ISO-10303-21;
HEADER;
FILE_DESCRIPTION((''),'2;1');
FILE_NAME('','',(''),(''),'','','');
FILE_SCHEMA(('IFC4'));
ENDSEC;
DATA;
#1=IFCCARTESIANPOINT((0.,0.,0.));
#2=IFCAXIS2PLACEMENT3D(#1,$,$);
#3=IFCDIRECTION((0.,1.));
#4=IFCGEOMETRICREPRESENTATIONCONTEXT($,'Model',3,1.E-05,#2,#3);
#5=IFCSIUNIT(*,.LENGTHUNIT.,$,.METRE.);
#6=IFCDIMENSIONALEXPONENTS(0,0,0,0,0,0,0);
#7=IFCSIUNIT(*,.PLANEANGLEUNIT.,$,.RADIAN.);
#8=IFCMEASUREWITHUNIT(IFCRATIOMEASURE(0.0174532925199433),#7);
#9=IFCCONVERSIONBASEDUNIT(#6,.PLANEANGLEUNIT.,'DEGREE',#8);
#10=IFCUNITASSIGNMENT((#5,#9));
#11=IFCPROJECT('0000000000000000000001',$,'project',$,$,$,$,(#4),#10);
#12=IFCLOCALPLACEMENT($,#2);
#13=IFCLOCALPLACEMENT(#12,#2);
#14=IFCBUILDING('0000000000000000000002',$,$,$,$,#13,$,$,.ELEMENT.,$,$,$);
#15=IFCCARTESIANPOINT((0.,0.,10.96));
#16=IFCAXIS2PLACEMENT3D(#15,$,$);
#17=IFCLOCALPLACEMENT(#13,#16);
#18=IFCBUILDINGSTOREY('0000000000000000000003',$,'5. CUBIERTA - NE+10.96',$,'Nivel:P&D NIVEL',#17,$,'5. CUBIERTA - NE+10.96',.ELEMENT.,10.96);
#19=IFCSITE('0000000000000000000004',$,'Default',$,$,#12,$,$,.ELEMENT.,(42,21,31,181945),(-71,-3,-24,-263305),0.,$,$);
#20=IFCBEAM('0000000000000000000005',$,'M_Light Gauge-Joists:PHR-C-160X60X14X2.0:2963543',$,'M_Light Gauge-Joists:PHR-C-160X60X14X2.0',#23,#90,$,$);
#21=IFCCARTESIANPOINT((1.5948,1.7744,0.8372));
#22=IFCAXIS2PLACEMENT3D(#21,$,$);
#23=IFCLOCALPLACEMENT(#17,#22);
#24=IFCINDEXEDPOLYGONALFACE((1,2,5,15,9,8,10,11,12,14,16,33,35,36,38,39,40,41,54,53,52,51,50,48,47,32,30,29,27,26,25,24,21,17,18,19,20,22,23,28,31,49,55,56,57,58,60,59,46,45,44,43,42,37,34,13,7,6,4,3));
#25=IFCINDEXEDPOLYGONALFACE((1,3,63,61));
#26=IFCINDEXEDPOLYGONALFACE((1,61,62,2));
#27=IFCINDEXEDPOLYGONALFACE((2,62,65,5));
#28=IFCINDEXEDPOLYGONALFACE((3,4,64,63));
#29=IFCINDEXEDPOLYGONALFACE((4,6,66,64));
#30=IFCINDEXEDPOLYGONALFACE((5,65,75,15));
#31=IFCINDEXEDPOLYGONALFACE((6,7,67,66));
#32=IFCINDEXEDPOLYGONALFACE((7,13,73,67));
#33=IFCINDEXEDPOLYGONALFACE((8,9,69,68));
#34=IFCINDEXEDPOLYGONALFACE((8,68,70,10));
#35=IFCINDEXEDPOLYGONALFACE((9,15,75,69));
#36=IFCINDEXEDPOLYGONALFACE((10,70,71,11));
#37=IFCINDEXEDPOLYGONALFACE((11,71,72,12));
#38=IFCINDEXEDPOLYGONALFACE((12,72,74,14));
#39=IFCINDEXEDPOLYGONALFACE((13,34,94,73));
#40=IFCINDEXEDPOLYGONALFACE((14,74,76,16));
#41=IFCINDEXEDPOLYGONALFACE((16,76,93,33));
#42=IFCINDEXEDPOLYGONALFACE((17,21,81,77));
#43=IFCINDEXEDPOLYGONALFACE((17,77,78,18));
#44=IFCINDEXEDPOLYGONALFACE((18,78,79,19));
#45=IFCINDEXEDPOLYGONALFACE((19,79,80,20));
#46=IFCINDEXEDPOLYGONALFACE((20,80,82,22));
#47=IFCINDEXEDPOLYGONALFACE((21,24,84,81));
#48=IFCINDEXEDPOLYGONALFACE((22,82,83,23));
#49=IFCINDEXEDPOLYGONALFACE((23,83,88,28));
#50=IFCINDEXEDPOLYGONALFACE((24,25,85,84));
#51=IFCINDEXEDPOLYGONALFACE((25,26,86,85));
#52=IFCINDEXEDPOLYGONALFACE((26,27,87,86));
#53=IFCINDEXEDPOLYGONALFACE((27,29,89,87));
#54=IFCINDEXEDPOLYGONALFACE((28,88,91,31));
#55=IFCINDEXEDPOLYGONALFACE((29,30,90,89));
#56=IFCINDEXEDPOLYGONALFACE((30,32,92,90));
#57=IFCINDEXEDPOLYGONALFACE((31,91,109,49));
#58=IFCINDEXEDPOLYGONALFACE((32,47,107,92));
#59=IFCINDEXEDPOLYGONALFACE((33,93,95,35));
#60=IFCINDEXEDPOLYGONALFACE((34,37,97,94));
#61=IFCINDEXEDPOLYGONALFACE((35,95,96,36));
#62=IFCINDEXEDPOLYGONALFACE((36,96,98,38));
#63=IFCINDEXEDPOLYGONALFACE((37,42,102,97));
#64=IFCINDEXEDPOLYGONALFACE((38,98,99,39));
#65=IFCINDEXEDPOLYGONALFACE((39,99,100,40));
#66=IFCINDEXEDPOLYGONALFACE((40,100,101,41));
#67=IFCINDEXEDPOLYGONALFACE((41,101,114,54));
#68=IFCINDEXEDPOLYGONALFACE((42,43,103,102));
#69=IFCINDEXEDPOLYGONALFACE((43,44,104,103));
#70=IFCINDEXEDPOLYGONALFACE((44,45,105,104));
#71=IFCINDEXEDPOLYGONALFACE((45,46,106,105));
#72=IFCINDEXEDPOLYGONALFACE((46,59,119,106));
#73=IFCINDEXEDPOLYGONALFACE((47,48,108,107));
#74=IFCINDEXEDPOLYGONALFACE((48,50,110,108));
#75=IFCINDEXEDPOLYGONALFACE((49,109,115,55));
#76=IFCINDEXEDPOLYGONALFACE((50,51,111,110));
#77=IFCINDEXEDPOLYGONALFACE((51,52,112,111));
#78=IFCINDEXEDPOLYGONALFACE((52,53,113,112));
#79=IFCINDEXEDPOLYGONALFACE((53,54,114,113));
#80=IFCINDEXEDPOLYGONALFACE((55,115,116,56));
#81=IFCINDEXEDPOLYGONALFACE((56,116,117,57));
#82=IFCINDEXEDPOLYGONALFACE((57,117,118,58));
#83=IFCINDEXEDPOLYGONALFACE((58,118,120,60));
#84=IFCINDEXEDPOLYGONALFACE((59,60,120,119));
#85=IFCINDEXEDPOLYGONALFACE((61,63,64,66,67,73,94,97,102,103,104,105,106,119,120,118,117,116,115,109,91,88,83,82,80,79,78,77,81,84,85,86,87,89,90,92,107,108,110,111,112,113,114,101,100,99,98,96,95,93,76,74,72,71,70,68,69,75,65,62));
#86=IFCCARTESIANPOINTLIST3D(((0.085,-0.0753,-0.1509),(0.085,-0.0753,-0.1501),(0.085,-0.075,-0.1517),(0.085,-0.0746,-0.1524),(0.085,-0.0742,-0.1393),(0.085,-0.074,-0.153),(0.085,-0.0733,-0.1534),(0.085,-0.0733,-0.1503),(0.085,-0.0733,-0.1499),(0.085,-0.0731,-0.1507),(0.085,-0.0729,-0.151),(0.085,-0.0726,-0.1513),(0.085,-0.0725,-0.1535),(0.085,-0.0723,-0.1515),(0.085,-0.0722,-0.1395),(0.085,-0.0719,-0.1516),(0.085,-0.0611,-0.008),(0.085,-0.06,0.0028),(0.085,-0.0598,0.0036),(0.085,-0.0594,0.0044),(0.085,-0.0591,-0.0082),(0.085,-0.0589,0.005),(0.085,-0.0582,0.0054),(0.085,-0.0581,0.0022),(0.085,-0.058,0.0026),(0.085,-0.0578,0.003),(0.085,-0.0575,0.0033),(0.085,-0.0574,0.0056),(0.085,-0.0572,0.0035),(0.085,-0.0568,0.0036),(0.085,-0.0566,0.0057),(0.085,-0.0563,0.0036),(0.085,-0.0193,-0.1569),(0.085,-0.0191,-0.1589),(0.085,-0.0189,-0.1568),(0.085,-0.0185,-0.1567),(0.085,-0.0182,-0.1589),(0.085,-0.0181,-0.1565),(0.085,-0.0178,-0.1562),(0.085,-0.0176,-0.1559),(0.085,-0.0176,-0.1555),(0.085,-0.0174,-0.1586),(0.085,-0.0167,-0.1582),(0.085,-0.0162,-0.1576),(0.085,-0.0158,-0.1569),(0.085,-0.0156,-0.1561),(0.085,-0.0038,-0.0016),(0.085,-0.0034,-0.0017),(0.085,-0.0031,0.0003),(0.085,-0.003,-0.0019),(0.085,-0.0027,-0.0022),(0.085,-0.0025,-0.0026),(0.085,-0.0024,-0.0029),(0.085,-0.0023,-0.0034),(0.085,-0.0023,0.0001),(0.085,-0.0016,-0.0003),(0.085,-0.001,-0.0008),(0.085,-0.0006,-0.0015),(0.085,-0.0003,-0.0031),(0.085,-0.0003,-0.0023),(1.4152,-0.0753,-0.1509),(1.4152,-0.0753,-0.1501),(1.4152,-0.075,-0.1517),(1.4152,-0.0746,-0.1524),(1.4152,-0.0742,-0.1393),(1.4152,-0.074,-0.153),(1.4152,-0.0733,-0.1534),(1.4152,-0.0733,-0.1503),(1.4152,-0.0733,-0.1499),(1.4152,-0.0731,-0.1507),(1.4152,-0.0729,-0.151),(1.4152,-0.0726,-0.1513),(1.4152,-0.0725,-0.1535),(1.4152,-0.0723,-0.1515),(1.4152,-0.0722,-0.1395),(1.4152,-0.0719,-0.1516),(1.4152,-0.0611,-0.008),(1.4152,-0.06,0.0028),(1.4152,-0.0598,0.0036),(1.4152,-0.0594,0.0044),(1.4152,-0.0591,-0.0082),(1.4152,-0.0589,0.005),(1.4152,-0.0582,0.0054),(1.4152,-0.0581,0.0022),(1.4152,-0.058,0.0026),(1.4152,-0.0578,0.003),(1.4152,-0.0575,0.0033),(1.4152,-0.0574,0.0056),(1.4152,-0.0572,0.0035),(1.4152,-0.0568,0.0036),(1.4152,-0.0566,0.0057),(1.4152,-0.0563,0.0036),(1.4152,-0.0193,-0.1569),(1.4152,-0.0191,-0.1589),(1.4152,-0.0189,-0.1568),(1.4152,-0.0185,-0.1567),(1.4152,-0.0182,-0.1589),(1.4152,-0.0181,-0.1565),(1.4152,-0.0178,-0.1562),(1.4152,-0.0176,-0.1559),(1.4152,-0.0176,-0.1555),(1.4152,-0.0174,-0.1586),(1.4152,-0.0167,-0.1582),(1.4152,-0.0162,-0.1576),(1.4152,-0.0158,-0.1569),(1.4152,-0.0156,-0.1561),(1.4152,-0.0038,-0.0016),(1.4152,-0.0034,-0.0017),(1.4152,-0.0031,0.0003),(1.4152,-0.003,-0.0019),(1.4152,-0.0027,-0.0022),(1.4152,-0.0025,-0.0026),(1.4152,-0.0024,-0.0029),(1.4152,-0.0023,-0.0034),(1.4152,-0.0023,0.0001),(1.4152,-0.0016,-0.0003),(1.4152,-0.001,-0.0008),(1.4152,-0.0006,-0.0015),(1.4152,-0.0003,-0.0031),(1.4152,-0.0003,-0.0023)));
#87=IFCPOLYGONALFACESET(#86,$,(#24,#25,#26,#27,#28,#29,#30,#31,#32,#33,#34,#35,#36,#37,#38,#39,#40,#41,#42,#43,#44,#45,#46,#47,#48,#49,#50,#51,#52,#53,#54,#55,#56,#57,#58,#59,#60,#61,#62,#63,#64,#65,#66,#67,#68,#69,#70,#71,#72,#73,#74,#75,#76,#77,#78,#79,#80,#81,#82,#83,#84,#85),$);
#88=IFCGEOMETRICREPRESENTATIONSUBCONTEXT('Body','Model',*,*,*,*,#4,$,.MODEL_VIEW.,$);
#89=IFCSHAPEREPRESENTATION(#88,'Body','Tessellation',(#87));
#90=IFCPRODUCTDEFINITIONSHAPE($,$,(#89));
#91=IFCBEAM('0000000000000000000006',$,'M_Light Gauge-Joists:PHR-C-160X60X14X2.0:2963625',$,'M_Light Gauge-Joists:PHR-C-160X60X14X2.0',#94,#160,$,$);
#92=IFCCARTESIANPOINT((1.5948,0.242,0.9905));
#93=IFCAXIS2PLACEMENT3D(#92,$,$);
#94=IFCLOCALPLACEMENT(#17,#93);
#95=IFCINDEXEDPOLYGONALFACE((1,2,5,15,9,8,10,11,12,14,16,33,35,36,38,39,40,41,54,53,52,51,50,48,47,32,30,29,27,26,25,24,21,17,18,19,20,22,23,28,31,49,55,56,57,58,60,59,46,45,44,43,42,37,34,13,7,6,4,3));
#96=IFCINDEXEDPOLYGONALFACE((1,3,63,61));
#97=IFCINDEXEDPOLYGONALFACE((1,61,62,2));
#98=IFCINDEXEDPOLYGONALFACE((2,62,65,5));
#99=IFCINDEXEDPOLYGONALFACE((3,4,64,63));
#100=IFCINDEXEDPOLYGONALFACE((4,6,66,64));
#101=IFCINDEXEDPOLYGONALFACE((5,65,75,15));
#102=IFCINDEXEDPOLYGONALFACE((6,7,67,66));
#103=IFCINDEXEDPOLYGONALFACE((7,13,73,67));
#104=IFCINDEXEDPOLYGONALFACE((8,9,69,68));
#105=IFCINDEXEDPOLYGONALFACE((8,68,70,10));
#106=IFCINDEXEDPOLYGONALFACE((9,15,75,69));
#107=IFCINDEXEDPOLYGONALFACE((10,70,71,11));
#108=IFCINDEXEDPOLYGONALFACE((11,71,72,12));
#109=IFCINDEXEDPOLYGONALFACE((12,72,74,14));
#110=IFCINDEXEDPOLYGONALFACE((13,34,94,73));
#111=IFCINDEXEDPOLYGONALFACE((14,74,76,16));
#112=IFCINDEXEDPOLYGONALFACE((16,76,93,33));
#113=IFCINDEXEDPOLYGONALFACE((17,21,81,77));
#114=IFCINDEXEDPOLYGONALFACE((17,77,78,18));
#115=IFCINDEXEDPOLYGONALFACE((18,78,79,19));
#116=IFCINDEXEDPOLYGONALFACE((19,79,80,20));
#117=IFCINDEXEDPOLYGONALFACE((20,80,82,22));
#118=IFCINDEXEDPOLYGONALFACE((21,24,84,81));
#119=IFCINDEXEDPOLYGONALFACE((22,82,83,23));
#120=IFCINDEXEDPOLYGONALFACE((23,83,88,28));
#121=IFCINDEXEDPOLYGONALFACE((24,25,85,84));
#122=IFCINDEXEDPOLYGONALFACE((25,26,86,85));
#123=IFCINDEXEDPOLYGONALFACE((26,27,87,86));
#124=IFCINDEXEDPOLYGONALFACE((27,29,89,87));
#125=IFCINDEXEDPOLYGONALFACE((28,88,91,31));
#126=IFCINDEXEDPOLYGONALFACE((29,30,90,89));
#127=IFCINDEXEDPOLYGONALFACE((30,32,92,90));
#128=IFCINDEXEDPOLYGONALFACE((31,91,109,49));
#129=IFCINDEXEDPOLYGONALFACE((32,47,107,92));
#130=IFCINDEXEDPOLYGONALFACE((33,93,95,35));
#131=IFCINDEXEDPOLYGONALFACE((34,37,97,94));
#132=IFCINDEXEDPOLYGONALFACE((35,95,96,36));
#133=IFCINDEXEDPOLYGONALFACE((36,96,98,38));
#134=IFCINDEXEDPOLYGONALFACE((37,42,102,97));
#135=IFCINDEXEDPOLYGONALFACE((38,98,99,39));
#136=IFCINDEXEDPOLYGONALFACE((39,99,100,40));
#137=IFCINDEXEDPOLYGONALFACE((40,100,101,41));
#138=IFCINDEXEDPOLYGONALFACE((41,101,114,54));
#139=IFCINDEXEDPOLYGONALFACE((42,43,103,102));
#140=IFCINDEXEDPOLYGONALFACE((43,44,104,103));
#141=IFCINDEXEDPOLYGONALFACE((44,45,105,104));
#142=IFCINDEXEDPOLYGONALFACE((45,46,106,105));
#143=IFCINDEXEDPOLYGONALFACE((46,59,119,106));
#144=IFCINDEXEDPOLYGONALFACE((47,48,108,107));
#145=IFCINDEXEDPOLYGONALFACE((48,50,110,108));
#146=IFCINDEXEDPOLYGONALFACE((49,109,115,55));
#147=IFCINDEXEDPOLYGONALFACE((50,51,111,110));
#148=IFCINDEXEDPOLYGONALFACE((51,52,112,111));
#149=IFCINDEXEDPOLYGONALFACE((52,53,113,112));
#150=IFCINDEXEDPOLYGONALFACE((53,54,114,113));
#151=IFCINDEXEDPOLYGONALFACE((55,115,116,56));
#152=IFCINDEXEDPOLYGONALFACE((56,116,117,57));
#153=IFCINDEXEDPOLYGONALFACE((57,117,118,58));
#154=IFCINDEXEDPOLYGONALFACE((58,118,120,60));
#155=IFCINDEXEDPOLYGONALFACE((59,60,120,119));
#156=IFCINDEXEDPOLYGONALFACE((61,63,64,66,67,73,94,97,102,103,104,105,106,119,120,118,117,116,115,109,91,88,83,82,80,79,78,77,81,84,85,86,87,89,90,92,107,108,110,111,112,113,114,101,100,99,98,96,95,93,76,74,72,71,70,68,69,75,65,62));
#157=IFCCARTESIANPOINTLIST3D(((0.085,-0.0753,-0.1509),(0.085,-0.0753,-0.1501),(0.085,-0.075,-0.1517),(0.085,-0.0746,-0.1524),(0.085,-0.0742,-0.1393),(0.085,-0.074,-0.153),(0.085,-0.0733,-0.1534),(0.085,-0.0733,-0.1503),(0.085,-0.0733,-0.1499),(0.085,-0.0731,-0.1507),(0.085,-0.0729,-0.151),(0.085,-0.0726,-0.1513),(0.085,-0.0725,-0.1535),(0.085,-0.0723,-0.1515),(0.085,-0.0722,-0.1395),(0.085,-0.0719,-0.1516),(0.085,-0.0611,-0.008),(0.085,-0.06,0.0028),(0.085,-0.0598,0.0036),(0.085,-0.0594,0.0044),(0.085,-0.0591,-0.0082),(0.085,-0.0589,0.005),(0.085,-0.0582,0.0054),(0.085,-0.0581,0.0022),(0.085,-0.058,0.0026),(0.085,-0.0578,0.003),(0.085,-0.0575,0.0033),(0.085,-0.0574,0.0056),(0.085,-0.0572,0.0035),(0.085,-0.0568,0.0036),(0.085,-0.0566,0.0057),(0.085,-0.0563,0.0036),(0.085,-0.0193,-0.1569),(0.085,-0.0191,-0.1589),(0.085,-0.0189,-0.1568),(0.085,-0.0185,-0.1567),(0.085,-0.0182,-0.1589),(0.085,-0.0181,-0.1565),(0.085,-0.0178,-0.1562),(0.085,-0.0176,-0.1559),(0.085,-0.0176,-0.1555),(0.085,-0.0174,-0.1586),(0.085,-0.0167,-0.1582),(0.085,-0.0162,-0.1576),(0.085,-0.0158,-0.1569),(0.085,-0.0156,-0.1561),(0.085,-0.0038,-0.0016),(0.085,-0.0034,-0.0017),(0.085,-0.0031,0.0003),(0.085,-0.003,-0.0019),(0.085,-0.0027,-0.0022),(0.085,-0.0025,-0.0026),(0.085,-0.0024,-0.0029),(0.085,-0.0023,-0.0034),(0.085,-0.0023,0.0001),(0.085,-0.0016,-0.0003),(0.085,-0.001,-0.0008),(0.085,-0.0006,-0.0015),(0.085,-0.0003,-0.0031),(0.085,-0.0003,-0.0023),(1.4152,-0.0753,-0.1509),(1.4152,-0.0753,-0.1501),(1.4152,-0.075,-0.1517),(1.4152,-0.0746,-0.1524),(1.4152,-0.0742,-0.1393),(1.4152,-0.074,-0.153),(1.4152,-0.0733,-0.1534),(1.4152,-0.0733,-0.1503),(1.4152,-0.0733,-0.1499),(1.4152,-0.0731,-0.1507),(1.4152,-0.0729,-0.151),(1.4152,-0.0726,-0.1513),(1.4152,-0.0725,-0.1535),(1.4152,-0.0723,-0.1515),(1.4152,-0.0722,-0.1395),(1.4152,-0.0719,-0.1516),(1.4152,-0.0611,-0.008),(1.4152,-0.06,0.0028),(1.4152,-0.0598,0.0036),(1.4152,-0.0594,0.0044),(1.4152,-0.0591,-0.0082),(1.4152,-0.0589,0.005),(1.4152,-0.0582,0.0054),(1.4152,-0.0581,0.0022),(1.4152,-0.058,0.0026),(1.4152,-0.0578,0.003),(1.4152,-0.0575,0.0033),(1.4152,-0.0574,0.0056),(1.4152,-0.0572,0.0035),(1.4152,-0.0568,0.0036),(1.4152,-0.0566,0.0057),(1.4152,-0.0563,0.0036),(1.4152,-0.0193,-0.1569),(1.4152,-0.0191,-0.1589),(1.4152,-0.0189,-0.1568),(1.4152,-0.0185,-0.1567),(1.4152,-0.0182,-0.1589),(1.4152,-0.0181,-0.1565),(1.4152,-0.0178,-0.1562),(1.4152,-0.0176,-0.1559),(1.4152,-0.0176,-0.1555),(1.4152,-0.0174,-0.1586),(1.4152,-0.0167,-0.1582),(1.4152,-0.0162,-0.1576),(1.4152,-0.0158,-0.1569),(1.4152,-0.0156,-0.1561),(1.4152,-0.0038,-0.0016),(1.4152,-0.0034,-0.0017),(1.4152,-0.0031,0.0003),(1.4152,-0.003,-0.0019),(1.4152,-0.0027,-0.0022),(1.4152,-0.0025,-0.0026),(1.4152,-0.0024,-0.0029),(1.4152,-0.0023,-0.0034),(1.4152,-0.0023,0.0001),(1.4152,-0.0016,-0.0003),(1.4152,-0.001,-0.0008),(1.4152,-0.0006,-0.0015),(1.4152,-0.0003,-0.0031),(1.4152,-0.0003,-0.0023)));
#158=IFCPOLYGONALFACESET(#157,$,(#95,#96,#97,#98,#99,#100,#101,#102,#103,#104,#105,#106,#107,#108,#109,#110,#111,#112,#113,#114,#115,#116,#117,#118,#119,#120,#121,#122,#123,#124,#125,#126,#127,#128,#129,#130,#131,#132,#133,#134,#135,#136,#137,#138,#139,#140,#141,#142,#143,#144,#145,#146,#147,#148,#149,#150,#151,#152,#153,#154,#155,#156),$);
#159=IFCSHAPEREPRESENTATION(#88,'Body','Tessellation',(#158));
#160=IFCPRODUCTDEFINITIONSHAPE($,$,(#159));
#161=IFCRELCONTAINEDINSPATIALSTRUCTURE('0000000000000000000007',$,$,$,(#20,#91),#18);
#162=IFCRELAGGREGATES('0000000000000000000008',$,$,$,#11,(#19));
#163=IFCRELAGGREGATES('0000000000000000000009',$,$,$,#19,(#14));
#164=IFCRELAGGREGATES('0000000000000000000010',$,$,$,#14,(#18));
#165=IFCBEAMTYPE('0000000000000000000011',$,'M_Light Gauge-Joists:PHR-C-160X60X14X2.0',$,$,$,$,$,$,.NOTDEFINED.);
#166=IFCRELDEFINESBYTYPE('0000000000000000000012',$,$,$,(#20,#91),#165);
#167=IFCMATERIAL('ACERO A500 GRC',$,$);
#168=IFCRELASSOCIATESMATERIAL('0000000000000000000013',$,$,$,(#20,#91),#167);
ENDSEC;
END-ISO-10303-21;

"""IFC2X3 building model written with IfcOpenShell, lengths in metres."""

from ifc_helpers import new_model, entity, si_unit, converted_unit, direction, frame, frame_2d, origin, place, context, subcontext, project, spatial, polyline, circle_curve, parameter, trimmed, segment, composite_curve, outline, extrude, material, type_object, element, save


model = new_model("IFC2X3")

# Units and contexts
model_context = context("Model", 3, precision=1e-05, world=origin(), true_north=direction((0.0, 1.0)))
body_context = subcontext(model_context, "Body", "Model", "MODEL_VIEW")
ifc_project = project(units=[si_unit("LENGTHUNIT", "METRE"), converted_unit("PLANEANGLEUNIT", "DEGREE", entity("IfcRatioMeasure", 0.0174532925199433), si_unit("PLANEANGLEUNIT", "RADIAN"), dimensions=[0, 0, 0, 0, 0, 0, 0])], contexts=[model_context])

# Site, building, storey
site_placement = place(None, origin())
site = spatial("IfcSite", under=ifc_project, at=site_placement, Name="Default", CompositionType="ELEMENT", RefLatitude=(42, 21, 31, 181945), RefLongitude=(-71, -3, -24, -263305), RefElevation=0.0)
building_placement = place(site_placement, origin())
building = spatial("IfcBuilding", under=site, at=building_placement, CompositionType="ELEMENT")
storey_placement = place(building_placement, frame((0.0, 0.0, 10.96)))
storey = spatial("IfcBuildingStorey", under=building, at=storey_placement, Name="5. CUBIERTA - NE+10.96", ObjectType="Nivel:P&D NIVEL", LongName="5. CUBIERTA - NE+10.96", CompositionType="ELEMENT", Elevation=10.96)

# Beams
ifc_material_1 = material(Name="ACERO A500 GRC")
beam_type_1 = type_object("IfcBeamType", Name="M_Light Gauge-Joists:PHR-C-160X60X14X2.0", PredefinedType="NOTDEFINED")
beam_1_placement = place(storey_placement, frame((1.5948, 1.7744, 0.8372)))
element("IfcBeam", 1, at=beam_1_placement, inside=storey, type_object=beam_type_1, material=ifc_material_1, Name="M_Light Gauge-Joists:PHR-C-160X60X14X2.0:2963543", ObjectType="M_Light Gauge-Joists:PHR-C-160X60X14X2.0", context=body_context, shape_type="SweptSolid", body=[
    extrude(outline(composite_curve([segment(polyline([(-0.0768, -0.0358), (0.0768, -0.0358)]), True, "CONTINUOUS"), segment(trimmed(circle_curve(frame_2d((0.0768, -0.0326), x_axis=(0.0, -1.0)), 0.0032), [parameter(0.0)], [parameter(90.0)], True, "PARAMETER"), True, "CONTINUOUS"), segment(polyline([(0.08, -0.0326), (0.08, 0.021)]), True, "CONTINUOUS"), segment(trimmed(circle_curve(frame_2d((0.0768, 0.021), x_axis=(1.0, 0.0)), 0.0032), [parameter(0.0)], [parameter(90.0)], True, "PARAMETER"), True, "CONTINUOUS"), segment(polyline([(0.0768, 0.0242), (0.066, 0.0242)]), True, "CONTINUOUS"), segment(polyline([(0.066, 0.0242), (0.066, 0.0222)]), True, "CONTINUOUS"), segment(polyline([(0.066, 0.0222), (0.0764, 0.0222)]), True, "CONTINUOUS"), segment(trimmed(circle_curve(frame_2d((0.0764, 0.0206), x_axis=(0.0, 1.0)), 0.0016), [parameter(270.0)], [parameter(0.0)], True, "PARAMETER"), False, "CONTINUOUS"), segment(polyline([(0.078, 0.0206), (0.078, -0.0322)]), True, "CONTINUOUS"), segment(trimmed(circle_curve(frame_2d((0.0764, -0.0322), x_axis=(1.0, 0.0)), 0.0016), [parameter(270.0)], [parameter(0.0)], True, "PARAMETER"), False, "CONTINUOUS"), segment(polyline([(0.0764, -0.0338), (-0.0764, -0.0338)]), True, "CONTINUOUS"), segment(trimmed(circle_curve(frame_2d((-0.0764, -0.0322), x_axis=(0.0, -1.0)), 0.0016), [parameter(270.0)], [parameter(0.0)], True, "PARAMETER"), False, "CONTINUOUS"), segment(polyline([(-0.078, -0.0322), (-0.078, 0.0206)]), True, "CONTINUOUS"), segment(trimmed(circle_curve(frame_2d((-0.0764, 0.0206), x_axis=(-1.0, 0.0)), 0.0016), [parameter(270.0)], [parameter(0.0)], True, "PARAMETER"), False, "CONTINUOUS"), segment(polyline([(-0.0764, 0.0222), (-0.066, 0.0222)]), True, "CONTINUOUS"), segment(polyline([(-0.066, 0.0222), (-0.066, 0.0242)]), True, "CONTINUOUS"), segment(polyline([(-0.066, 0.0242), (-0.0768, 0.0242)]), True, "CONTINUOUS"), segment(trimmed(circle_curve(frame_2d((-0.0768, 0.021), x_axis=(0.0, 1.0)), 0.0032), [parameter(0.0)], [parameter(90.0)], True, "PARAMETER"), True, "CONTINUOUS"), segment(polyline([(-0.08, 0.021), (-0.08, -0.0326)]), True, "CONTINUOUS"), segment(trimmed(circle_curve(frame_2d((-0.0768, -0.0326), x_axis=(-1.0, 0.0)), 0.0032), [parameter(0.0)], [parameter(90.0)], True, "PARAMETER"), True, "CONTINUOUS")], self_intersect=False)), frame((0.085, -0.0436, -0.076), z_axis=(1.0, 0.0, 0.0), x_axis=(0.0, 0.099504, 0.995037)), (0.0, 0.0, 1.0), 1.3302),
])
beam_2_placement = place(storey_placement, frame((1.5948, 0.242, 0.9905)))
element("IfcBeam", 2, at=beam_2_placement, inside=storey, type_object=beam_type_1, material=ifc_material_1, Name="M_Light Gauge-Joists:PHR-C-160X60X14X2.0:2963625", ObjectType="M_Light Gauge-Joists:PHR-C-160X60X14X2.0", context=body_context, shape_type="SweptSolid", body=[
    extrude(outline(composite_curve([segment(polyline([(-0.0768, -0.0358), (0.0768, -0.0358)]), True, "CONTINUOUS"), segment(trimmed(circle_curve(frame_2d((0.0768, -0.0326), x_axis=(0.0, -1.0)), 0.0032), [parameter(0.0)], [parameter(90.0)], True, "PARAMETER"), True, "CONTINUOUS"), segment(polyline([(0.08, -0.0326), (0.08, 0.021)]), True, "CONTINUOUS"), segment(trimmed(circle_curve(frame_2d((0.0768, 0.021), x_axis=(1.0, 0.0)), 0.0032), [parameter(0.0)], [parameter(90.0)], True, "PARAMETER"), True, "CONTINUOUS"), segment(polyline([(0.0768, 0.0242), (0.066, 0.0242)]), True, "CONTINUOUS"), segment(polyline([(0.066, 0.0242), (0.066, 0.0222)]), True, "CONTINUOUS"), segment(polyline([(0.066, 0.0222), (0.0764, 0.0222)]), True, "CONTINUOUS"), segment(trimmed(circle_curve(frame_2d((0.0764, 0.0206), x_axis=(0.0, 1.0)), 0.0016), [parameter(270.0)], [parameter(0.0)], True, "PARAMETER"), False, "CONTINUOUS"), segment(polyline([(0.078, 0.0206), (0.078, -0.0322)]), True, "CONTINUOUS"), segment(trimmed(circle_curve(frame_2d((0.0764, -0.0322), x_axis=(1.0, 0.0)), 0.0016), [parameter(270.0)], [parameter(0.0)], True, "PARAMETER"), False, "CONTINUOUS"), segment(polyline([(0.0764, -0.0338), (-0.0764, -0.0338)]), True, "CONTINUOUS"), segment(trimmed(circle_curve(frame_2d((-0.0764, -0.0322), x_axis=(0.0, -1.0)), 0.0016), [parameter(270.0)], [parameter(0.0)], True, "PARAMETER"), False, "CONTINUOUS"), segment(polyline([(-0.078, -0.0322), (-0.078, 0.0206)]), True, "CONTINUOUS"), segment(trimmed(circle_curve(frame_2d((-0.0764, 0.0206), x_axis=(-1.0, 0.0)), 0.0016), [parameter(270.0)], [parameter(0.0)], True, "PARAMETER"), False, "CONTINUOUS"), segment(polyline([(-0.0764, 0.0222), (-0.066, 0.0222)]), True, "CONTINUOUS"), segment(polyline([(-0.066, 0.0222), (-0.066, 0.0242)]), True, "CONTINUOUS"), segment(polyline([(-0.066, 0.0242), (-0.0768, 0.0242)]), True, "CONTINUOUS"), segment(trimmed(circle_curve(frame_2d((-0.0768, 0.021), x_axis=(0.0, 1.0)), 0.0032), [parameter(0.0)], [parameter(90.0)], True, "PARAMETER"), True, "CONTINUOUS"), segment(polyline([(-0.08, 0.021), (-0.08, -0.0326)]), True, "CONTINUOUS"), segment(trimmed(circle_curve(frame_2d((-0.0768, -0.0326), x_axis=(-1.0, 0.0)), 0.0032), [parameter(0.0)], [parameter(90.0)], True, "PARAMETER"), True, "CONTINUOUS")], self_intersect=False)), frame((0.085, -0.0436, -0.076), z_axis=(1.0, 0.0, 0.0), x_axis=(0.0, 0.099504, 0.995037)), (0.0, 0.0, 1.0), 1.3302),
])

save(model, "model.ifc")
